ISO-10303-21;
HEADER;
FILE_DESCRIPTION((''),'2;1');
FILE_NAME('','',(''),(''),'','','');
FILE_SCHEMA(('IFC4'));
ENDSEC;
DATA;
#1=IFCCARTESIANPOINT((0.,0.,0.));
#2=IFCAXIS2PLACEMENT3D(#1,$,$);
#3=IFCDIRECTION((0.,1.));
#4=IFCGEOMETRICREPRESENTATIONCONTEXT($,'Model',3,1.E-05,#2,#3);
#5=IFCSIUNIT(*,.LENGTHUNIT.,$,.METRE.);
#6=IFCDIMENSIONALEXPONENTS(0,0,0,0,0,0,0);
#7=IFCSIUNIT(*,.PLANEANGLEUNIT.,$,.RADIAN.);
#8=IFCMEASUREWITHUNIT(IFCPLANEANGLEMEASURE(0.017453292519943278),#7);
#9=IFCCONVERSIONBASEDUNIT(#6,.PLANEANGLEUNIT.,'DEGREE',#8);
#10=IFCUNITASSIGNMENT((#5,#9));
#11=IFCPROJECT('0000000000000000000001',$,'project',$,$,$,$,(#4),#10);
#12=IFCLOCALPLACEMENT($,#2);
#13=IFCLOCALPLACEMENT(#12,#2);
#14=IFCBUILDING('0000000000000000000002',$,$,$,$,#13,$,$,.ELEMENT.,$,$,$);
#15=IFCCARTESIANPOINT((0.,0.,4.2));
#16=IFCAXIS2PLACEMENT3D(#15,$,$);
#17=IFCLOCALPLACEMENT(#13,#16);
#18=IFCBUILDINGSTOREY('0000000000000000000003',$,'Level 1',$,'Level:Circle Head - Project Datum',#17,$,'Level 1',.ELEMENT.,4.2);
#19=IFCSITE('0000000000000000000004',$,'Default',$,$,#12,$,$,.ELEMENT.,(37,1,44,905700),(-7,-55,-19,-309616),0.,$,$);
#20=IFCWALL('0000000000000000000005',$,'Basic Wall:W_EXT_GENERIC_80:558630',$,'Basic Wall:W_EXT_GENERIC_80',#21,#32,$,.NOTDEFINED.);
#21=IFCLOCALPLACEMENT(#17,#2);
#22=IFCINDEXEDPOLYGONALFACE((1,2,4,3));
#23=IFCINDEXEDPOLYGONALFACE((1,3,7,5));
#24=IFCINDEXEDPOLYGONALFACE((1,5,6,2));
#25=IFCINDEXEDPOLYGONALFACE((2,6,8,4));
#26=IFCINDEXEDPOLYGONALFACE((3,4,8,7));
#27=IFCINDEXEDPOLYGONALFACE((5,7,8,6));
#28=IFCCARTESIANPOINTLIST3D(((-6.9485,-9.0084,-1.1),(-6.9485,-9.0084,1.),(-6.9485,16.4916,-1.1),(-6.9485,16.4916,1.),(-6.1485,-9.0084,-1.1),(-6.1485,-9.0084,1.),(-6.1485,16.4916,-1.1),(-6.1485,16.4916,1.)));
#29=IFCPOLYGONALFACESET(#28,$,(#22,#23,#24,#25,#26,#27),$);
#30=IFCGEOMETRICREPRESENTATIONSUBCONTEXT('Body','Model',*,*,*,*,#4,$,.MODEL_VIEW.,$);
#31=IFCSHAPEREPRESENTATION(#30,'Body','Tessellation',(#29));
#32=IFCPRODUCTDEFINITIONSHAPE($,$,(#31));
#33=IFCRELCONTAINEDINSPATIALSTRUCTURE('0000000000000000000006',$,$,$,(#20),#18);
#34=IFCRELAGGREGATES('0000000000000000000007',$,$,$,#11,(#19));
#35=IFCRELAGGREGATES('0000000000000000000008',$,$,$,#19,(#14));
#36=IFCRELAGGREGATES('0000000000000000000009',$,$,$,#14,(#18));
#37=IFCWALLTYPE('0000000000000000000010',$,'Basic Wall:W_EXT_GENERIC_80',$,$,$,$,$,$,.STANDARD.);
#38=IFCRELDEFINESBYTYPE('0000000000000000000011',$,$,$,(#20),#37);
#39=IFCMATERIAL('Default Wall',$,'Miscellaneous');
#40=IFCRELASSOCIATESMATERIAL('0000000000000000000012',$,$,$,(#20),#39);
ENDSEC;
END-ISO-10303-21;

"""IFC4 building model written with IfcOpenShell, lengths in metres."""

from ifc_helpers import new_model, entity, si_unit, converted_unit, direction, frame, origin, place, context, subcontext, project, spatial, indexed_curve, outline, extrude, material, type_object, element, save


model = new_model("IFC4")

# Units and contexts
model_context = context("Model", 3, precision=1e-05, world=origin(), true_north=direction((0.0, 1.0)))
body_context = subcontext(model_context, "Body", "Model", "MODEL_VIEW")
ifc_project = project(units=[si_unit("LENGTHUNIT", "METRE"), converted_unit("PLANEANGLEUNIT", "DEGREE", entity("IfcPlaneAngleMeasure", 0.017453292519943278), si_unit("PLANEANGLEUNIT", "RADIAN"), dimensions=[0, 0, 0, 0, 0, 0, 0])], contexts=[model_context])

# Site, building, storey
site_placement = place(None, origin())
site = spatial("IfcSite", under=ifc_project, at=site_placement, Name="Default", CompositionType="ELEMENT", RefLatitude=(37, 1, 44, 905700), RefLongitude=(-7, -55, -19, -309616), RefElevation=0.0)
building_placement = place(site_placement, origin())
building = spatial("IfcBuilding", under=site, at=building_placement, CompositionType="ELEMENT")
storey_placement = place(building_placement, frame((0.0, 0.0, 4.2)))
storey = spatial("IfcBuildingStorey", under=building, at=storey_placement, Name="Level 1", ObjectType="Level:Circle Head - Project Datum", LongName="Level 1", CompositionType="ELEMENT", Elevation=4.2)

# Wall
ifc_material_1 = material(Name="Default Wall", Category="Miscellaneous")
wall_type = type_object("IfcWallType", Name="Basic Wall:W_EXT_GENERIC_80", PredefinedType="STANDARD")
wall_placement = place(storey_placement, frame((-6.5485, 16.4916, -1.1), z_axis=(0.0, 0.0, 1.0), x_axis=(0.0, -1.0, 0.0)))
element("IfcWall", 1, at=wall_placement, inside=storey, type_object=wall_type, material=ifc_material_1, Name="Basic Wall:W_EXT_GENERIC_80:558630", ObjectType="Basic Wall:W_EXT_GENERIC_80", PredefinedType="NOTDEFINED", context=body_context, shape_type="SweptSolid", body=[
    extrude(outline(indexed_curve([(25.5, 0.4), (0.0, 0.4), (0.0, -0.4), (25.5, -0.4), (25.5, 0.4)], self_intersect=False)), origin(), (0.0, 0.0, 1.0), 2.1),
])

save(model, "model.ifc")
